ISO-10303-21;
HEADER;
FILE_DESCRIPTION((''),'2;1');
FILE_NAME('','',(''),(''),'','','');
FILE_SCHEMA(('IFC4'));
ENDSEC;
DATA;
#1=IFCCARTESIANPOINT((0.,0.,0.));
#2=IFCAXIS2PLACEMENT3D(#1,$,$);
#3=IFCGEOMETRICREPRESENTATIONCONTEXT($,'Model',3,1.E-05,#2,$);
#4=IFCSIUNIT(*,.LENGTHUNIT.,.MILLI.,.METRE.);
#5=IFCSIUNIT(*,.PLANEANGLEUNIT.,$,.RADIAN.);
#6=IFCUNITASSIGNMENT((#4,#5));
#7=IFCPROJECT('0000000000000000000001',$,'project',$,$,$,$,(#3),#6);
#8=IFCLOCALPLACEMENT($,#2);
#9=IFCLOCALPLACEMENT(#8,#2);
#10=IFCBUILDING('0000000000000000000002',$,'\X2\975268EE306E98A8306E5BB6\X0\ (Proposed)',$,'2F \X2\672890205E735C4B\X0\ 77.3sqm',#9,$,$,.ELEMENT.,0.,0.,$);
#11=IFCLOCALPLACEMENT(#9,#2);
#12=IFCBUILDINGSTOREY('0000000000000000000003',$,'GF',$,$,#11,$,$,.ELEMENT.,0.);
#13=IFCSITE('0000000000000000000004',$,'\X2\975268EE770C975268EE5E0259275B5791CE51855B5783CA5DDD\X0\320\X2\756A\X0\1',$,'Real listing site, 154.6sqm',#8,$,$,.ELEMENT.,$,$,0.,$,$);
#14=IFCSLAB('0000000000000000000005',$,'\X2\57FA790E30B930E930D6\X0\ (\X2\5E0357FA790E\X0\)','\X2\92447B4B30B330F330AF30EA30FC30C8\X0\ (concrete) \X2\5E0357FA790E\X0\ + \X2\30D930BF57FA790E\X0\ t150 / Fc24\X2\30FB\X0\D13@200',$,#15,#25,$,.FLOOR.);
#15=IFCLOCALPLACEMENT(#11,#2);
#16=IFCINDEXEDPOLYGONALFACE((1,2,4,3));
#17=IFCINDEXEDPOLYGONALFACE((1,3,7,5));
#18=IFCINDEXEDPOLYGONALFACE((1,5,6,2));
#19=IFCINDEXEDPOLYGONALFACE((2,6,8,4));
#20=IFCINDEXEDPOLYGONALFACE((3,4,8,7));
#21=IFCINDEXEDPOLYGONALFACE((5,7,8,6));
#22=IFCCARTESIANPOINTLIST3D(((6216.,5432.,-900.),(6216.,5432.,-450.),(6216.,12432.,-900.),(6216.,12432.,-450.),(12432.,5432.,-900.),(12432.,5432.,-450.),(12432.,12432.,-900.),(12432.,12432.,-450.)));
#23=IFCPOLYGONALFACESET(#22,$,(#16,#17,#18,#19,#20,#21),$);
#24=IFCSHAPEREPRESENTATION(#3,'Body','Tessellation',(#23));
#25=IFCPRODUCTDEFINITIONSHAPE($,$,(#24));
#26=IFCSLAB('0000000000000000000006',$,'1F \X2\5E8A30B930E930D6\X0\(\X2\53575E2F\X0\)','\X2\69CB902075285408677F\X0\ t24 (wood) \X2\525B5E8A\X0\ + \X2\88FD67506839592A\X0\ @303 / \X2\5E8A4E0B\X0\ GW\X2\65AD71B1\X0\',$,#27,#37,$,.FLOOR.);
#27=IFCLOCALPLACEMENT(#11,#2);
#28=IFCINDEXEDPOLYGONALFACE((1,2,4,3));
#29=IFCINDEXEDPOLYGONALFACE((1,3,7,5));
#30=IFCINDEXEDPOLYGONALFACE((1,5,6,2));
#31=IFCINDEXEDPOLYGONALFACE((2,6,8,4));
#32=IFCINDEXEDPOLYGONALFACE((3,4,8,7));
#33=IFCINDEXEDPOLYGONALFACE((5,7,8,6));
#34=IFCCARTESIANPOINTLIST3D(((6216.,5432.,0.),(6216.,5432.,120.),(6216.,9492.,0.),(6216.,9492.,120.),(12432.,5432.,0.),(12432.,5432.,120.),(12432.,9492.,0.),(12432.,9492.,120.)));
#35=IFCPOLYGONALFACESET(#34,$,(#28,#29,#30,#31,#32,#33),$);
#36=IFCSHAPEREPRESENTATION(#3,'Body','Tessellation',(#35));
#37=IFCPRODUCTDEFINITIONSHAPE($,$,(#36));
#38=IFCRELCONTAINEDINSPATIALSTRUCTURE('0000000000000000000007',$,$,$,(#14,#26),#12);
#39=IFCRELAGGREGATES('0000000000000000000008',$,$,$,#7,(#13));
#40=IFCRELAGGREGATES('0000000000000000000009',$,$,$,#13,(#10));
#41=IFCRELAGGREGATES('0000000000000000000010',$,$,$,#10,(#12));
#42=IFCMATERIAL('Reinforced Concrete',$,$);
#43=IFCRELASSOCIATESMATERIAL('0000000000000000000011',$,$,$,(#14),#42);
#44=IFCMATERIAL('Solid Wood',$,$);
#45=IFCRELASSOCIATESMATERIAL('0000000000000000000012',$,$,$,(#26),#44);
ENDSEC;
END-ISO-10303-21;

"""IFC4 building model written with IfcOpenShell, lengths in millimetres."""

from ifc_helpers import new_model, si_unit, frame, frame_2d, origin, place, context, project, spatial, rectangle, extrude, material, element, save


model = new_model("IFC4")

# Units and contexts
model_context = context("Model", 3, precision=1e-05, world=origin())
ifc_project = project(units=[si_unit("LENGTHUNIT", "METRE", prefix="MILLI"), si_unit("PLANEANGLEUNIT", "RADIAN")], contexts=[model_context])

# Site, building, storey
site_placement = place(None, origin())
site = spatial("IfcSite", under=ifc_project, at=site_placement, Name="青森県青森市大字野内字菊川320番1", ObjectType="Real listing site, 154.6sqm", CompositionType="ELEMENT", RefElevation=0.0)
building_placement = place(site_placement, origin())
building = spatial("IfcBuilding", under=site, at=building_placement, Name="青森の風の家 (Proposed)", ObjectType="2F 木造平屋 77.3sqm", CompositionType="ELEMENT", ElevationOfRefHeight=0.0, ElevationOfTerrain=0.0)
storey_placement = place(building_placement, origin())
storey = spatial("IfcBuildingStorey", under=building, at=storey_placement, Name="GF", CompositionType="ELEMENT", Elevation=0.0)

# Slabs
ifc_material_1 = material(Name="Reinforced Concrete")
slab_1_placement = place(storey_placement, frame((3108.0, 2716.0, -450.0)))
element("IfcSlab", 1, at=slab_1_placement, inside=storey, material=ifc_material_1, Name="基礎スラブ (布基礎)", Description="鉄筋コンクリート (concrete) 布基礎 + ベタ基礎 t150 / Fc24・D13@200", PredefinedType="FLOOR", context=model_context, shape_type="SweptSolid", body=[
    extrude(rectangle(XDim=6216.0, YDim=7000.0, at=frame_2d((3108.0, 3500.0))), frame((3108.0, 2716.0, -450.0)), (0.0, 0.0, 1.0), 450.0),
])
ifc_material_2 = material(Name="Solid Wood")
slab_2_placement = place(storey_placement, frame((3108.0, 2716.0, 0.0)))
element("IfcSlab", 2, at=slab_2_placement, inside=storey, material=ifc_material_2, Name="1F 床スラブ(南帯)", Description="構造用合板 t24 (wood) 剛床 + 製材根太 @303 / 床下 GW断熱", PredefinedType="FLOOR", context=model_context, shape_type="SweptSolid", body=[
    extrude(rectangle(XDim=6216.0, YDim=4060.0, at=frame_2d((3108.0, 2030.0))), frame((3108.0, 2716.0, 0.0)), (0.0, 0.0, 1.0), 120.0),
])

save(model, "model.ifc")
